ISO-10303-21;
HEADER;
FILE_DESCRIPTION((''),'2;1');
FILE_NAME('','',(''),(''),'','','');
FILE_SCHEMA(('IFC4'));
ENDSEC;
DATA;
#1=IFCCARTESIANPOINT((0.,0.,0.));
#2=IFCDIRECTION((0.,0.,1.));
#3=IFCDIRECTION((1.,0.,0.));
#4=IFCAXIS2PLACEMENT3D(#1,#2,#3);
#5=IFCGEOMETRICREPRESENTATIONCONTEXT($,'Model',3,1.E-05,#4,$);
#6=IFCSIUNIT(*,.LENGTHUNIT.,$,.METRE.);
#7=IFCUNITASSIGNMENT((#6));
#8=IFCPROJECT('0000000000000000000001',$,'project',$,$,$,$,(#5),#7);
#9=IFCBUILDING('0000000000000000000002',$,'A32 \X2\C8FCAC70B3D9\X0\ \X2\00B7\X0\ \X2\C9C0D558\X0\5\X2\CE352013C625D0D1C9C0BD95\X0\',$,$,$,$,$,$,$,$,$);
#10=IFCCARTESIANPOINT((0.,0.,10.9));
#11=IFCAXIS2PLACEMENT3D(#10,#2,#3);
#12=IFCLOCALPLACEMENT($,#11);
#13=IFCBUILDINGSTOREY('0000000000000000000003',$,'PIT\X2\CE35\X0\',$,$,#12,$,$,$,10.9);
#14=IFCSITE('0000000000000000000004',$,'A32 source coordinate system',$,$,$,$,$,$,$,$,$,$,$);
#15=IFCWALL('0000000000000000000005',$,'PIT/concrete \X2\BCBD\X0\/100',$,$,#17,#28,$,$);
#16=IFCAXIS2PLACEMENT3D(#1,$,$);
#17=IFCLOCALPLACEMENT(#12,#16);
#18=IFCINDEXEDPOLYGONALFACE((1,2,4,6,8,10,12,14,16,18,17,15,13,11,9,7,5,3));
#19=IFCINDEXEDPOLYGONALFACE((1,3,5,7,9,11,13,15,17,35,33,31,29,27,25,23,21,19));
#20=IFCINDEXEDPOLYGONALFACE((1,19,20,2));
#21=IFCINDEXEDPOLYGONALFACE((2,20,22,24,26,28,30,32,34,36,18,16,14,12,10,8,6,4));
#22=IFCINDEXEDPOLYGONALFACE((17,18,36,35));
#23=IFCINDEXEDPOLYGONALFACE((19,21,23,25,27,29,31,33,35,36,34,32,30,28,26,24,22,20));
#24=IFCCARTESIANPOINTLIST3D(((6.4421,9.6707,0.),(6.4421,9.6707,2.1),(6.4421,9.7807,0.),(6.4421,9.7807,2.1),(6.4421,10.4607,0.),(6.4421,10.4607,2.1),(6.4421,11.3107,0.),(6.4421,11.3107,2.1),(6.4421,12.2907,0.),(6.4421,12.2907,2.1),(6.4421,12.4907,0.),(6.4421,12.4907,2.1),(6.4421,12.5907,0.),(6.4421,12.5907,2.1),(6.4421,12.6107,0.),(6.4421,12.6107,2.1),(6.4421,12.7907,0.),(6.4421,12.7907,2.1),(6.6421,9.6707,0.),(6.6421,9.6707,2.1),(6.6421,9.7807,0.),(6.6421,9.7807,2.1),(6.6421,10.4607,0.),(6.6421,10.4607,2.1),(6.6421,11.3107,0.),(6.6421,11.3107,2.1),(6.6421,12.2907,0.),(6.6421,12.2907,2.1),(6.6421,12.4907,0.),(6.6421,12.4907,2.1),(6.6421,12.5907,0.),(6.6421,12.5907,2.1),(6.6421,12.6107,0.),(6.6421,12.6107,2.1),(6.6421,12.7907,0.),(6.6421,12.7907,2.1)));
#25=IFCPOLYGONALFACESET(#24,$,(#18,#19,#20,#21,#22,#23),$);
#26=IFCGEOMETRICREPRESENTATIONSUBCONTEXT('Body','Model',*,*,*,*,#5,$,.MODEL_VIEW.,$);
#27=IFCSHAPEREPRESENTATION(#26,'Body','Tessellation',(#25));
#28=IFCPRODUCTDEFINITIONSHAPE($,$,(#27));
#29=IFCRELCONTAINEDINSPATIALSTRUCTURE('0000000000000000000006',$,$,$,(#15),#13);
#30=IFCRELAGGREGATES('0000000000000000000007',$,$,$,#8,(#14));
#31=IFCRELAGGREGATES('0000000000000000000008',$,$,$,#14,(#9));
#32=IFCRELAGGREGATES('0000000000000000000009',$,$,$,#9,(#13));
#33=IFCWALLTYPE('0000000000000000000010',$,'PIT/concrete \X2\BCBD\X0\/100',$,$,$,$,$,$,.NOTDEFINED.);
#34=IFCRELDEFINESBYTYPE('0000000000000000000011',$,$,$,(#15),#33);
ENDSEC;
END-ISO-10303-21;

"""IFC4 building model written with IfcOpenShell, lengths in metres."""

from ifc_helpers import new_model, si_unit, frame, origin, origin_with_axes, place, context, subcontext, project, spatial, polyline, outline, extrude, source, transform, mapped, type_object, type_shapes, element, save


model = new_model("IFC4")

# Units and contexts
model_context = context("Model", 3, precision=1e-05, world=origin_with_axes())
body_context = subcontext(model_context, "Body", "Model", "MODEL_VIEW")
ifc_project = project(units=[si_unit("LENGTHUNIT", "METRE")], contexts=[model_context])

# Site, building, storey
site = spatial("IfcSite", under=ifc_project, Name="A32 source coordinate system")
building = spatial("IfcBuilding", under=site, Name="A32 주거동 · 지하5층–옥탑지붕")
storey_placement = place(None, frame((0.0, 0.0, 10.9), z_axis=(0.0, 0.0, 1.0), x_axis=(1.0, 0.0, 0.0)))
storey = spatial("IfcBuildingStorey", under=building, at=storey_placement, Name="PIT층", Elevation=10.9)

# Wall
wall_type_1 = type_object("IfcWallType", Name="PIT/concrete 벽/100", PredefinedType="NOTDEFINED")
shared_shape_1 = source(origin(), body_context, "Body", "SweptSolid", [
    extrude(outline(polyline([(6.4421, 11.3107), (6.4421, 12.2907), (6.4421, 12.4907), (6.4421, 12.5907), (6.4421, 12.6107), (6.4421, 12.7907), (6.6421, 12.7907), (6.6421, 12.6107), (6.6421, 12.5907), (6.6421, 12.4907), (6.6421, 12.2907), (6.6421, 11.3107), (6.6421, 10.4607), (6.6421, 9.7807), (6.6421, 9.6707), (6.4421, 9.6707), (6.4421, 9.7807), (6.4421, 10.4607), (6.4421, 11.3107)])), origin(), (0.0, 0.0, 1.0), 2.1),
])
type_shapes(wall_type_1, [shared_shape_1])
wall_1_placement = place(storey_placement, origin_with_axes())
element("IfcWall", 1, at=wall_1_placement, inside=storey, type_object=wall_type_1, Name="PIT/concrete 벽/100", context=body_context, shape_type="MappedRepresentation", body=[
    mapped(shared_shape_1, transform((0.0, 0.0, 0.0), scale=1.0)),
])

save(model, "model.ifc")
